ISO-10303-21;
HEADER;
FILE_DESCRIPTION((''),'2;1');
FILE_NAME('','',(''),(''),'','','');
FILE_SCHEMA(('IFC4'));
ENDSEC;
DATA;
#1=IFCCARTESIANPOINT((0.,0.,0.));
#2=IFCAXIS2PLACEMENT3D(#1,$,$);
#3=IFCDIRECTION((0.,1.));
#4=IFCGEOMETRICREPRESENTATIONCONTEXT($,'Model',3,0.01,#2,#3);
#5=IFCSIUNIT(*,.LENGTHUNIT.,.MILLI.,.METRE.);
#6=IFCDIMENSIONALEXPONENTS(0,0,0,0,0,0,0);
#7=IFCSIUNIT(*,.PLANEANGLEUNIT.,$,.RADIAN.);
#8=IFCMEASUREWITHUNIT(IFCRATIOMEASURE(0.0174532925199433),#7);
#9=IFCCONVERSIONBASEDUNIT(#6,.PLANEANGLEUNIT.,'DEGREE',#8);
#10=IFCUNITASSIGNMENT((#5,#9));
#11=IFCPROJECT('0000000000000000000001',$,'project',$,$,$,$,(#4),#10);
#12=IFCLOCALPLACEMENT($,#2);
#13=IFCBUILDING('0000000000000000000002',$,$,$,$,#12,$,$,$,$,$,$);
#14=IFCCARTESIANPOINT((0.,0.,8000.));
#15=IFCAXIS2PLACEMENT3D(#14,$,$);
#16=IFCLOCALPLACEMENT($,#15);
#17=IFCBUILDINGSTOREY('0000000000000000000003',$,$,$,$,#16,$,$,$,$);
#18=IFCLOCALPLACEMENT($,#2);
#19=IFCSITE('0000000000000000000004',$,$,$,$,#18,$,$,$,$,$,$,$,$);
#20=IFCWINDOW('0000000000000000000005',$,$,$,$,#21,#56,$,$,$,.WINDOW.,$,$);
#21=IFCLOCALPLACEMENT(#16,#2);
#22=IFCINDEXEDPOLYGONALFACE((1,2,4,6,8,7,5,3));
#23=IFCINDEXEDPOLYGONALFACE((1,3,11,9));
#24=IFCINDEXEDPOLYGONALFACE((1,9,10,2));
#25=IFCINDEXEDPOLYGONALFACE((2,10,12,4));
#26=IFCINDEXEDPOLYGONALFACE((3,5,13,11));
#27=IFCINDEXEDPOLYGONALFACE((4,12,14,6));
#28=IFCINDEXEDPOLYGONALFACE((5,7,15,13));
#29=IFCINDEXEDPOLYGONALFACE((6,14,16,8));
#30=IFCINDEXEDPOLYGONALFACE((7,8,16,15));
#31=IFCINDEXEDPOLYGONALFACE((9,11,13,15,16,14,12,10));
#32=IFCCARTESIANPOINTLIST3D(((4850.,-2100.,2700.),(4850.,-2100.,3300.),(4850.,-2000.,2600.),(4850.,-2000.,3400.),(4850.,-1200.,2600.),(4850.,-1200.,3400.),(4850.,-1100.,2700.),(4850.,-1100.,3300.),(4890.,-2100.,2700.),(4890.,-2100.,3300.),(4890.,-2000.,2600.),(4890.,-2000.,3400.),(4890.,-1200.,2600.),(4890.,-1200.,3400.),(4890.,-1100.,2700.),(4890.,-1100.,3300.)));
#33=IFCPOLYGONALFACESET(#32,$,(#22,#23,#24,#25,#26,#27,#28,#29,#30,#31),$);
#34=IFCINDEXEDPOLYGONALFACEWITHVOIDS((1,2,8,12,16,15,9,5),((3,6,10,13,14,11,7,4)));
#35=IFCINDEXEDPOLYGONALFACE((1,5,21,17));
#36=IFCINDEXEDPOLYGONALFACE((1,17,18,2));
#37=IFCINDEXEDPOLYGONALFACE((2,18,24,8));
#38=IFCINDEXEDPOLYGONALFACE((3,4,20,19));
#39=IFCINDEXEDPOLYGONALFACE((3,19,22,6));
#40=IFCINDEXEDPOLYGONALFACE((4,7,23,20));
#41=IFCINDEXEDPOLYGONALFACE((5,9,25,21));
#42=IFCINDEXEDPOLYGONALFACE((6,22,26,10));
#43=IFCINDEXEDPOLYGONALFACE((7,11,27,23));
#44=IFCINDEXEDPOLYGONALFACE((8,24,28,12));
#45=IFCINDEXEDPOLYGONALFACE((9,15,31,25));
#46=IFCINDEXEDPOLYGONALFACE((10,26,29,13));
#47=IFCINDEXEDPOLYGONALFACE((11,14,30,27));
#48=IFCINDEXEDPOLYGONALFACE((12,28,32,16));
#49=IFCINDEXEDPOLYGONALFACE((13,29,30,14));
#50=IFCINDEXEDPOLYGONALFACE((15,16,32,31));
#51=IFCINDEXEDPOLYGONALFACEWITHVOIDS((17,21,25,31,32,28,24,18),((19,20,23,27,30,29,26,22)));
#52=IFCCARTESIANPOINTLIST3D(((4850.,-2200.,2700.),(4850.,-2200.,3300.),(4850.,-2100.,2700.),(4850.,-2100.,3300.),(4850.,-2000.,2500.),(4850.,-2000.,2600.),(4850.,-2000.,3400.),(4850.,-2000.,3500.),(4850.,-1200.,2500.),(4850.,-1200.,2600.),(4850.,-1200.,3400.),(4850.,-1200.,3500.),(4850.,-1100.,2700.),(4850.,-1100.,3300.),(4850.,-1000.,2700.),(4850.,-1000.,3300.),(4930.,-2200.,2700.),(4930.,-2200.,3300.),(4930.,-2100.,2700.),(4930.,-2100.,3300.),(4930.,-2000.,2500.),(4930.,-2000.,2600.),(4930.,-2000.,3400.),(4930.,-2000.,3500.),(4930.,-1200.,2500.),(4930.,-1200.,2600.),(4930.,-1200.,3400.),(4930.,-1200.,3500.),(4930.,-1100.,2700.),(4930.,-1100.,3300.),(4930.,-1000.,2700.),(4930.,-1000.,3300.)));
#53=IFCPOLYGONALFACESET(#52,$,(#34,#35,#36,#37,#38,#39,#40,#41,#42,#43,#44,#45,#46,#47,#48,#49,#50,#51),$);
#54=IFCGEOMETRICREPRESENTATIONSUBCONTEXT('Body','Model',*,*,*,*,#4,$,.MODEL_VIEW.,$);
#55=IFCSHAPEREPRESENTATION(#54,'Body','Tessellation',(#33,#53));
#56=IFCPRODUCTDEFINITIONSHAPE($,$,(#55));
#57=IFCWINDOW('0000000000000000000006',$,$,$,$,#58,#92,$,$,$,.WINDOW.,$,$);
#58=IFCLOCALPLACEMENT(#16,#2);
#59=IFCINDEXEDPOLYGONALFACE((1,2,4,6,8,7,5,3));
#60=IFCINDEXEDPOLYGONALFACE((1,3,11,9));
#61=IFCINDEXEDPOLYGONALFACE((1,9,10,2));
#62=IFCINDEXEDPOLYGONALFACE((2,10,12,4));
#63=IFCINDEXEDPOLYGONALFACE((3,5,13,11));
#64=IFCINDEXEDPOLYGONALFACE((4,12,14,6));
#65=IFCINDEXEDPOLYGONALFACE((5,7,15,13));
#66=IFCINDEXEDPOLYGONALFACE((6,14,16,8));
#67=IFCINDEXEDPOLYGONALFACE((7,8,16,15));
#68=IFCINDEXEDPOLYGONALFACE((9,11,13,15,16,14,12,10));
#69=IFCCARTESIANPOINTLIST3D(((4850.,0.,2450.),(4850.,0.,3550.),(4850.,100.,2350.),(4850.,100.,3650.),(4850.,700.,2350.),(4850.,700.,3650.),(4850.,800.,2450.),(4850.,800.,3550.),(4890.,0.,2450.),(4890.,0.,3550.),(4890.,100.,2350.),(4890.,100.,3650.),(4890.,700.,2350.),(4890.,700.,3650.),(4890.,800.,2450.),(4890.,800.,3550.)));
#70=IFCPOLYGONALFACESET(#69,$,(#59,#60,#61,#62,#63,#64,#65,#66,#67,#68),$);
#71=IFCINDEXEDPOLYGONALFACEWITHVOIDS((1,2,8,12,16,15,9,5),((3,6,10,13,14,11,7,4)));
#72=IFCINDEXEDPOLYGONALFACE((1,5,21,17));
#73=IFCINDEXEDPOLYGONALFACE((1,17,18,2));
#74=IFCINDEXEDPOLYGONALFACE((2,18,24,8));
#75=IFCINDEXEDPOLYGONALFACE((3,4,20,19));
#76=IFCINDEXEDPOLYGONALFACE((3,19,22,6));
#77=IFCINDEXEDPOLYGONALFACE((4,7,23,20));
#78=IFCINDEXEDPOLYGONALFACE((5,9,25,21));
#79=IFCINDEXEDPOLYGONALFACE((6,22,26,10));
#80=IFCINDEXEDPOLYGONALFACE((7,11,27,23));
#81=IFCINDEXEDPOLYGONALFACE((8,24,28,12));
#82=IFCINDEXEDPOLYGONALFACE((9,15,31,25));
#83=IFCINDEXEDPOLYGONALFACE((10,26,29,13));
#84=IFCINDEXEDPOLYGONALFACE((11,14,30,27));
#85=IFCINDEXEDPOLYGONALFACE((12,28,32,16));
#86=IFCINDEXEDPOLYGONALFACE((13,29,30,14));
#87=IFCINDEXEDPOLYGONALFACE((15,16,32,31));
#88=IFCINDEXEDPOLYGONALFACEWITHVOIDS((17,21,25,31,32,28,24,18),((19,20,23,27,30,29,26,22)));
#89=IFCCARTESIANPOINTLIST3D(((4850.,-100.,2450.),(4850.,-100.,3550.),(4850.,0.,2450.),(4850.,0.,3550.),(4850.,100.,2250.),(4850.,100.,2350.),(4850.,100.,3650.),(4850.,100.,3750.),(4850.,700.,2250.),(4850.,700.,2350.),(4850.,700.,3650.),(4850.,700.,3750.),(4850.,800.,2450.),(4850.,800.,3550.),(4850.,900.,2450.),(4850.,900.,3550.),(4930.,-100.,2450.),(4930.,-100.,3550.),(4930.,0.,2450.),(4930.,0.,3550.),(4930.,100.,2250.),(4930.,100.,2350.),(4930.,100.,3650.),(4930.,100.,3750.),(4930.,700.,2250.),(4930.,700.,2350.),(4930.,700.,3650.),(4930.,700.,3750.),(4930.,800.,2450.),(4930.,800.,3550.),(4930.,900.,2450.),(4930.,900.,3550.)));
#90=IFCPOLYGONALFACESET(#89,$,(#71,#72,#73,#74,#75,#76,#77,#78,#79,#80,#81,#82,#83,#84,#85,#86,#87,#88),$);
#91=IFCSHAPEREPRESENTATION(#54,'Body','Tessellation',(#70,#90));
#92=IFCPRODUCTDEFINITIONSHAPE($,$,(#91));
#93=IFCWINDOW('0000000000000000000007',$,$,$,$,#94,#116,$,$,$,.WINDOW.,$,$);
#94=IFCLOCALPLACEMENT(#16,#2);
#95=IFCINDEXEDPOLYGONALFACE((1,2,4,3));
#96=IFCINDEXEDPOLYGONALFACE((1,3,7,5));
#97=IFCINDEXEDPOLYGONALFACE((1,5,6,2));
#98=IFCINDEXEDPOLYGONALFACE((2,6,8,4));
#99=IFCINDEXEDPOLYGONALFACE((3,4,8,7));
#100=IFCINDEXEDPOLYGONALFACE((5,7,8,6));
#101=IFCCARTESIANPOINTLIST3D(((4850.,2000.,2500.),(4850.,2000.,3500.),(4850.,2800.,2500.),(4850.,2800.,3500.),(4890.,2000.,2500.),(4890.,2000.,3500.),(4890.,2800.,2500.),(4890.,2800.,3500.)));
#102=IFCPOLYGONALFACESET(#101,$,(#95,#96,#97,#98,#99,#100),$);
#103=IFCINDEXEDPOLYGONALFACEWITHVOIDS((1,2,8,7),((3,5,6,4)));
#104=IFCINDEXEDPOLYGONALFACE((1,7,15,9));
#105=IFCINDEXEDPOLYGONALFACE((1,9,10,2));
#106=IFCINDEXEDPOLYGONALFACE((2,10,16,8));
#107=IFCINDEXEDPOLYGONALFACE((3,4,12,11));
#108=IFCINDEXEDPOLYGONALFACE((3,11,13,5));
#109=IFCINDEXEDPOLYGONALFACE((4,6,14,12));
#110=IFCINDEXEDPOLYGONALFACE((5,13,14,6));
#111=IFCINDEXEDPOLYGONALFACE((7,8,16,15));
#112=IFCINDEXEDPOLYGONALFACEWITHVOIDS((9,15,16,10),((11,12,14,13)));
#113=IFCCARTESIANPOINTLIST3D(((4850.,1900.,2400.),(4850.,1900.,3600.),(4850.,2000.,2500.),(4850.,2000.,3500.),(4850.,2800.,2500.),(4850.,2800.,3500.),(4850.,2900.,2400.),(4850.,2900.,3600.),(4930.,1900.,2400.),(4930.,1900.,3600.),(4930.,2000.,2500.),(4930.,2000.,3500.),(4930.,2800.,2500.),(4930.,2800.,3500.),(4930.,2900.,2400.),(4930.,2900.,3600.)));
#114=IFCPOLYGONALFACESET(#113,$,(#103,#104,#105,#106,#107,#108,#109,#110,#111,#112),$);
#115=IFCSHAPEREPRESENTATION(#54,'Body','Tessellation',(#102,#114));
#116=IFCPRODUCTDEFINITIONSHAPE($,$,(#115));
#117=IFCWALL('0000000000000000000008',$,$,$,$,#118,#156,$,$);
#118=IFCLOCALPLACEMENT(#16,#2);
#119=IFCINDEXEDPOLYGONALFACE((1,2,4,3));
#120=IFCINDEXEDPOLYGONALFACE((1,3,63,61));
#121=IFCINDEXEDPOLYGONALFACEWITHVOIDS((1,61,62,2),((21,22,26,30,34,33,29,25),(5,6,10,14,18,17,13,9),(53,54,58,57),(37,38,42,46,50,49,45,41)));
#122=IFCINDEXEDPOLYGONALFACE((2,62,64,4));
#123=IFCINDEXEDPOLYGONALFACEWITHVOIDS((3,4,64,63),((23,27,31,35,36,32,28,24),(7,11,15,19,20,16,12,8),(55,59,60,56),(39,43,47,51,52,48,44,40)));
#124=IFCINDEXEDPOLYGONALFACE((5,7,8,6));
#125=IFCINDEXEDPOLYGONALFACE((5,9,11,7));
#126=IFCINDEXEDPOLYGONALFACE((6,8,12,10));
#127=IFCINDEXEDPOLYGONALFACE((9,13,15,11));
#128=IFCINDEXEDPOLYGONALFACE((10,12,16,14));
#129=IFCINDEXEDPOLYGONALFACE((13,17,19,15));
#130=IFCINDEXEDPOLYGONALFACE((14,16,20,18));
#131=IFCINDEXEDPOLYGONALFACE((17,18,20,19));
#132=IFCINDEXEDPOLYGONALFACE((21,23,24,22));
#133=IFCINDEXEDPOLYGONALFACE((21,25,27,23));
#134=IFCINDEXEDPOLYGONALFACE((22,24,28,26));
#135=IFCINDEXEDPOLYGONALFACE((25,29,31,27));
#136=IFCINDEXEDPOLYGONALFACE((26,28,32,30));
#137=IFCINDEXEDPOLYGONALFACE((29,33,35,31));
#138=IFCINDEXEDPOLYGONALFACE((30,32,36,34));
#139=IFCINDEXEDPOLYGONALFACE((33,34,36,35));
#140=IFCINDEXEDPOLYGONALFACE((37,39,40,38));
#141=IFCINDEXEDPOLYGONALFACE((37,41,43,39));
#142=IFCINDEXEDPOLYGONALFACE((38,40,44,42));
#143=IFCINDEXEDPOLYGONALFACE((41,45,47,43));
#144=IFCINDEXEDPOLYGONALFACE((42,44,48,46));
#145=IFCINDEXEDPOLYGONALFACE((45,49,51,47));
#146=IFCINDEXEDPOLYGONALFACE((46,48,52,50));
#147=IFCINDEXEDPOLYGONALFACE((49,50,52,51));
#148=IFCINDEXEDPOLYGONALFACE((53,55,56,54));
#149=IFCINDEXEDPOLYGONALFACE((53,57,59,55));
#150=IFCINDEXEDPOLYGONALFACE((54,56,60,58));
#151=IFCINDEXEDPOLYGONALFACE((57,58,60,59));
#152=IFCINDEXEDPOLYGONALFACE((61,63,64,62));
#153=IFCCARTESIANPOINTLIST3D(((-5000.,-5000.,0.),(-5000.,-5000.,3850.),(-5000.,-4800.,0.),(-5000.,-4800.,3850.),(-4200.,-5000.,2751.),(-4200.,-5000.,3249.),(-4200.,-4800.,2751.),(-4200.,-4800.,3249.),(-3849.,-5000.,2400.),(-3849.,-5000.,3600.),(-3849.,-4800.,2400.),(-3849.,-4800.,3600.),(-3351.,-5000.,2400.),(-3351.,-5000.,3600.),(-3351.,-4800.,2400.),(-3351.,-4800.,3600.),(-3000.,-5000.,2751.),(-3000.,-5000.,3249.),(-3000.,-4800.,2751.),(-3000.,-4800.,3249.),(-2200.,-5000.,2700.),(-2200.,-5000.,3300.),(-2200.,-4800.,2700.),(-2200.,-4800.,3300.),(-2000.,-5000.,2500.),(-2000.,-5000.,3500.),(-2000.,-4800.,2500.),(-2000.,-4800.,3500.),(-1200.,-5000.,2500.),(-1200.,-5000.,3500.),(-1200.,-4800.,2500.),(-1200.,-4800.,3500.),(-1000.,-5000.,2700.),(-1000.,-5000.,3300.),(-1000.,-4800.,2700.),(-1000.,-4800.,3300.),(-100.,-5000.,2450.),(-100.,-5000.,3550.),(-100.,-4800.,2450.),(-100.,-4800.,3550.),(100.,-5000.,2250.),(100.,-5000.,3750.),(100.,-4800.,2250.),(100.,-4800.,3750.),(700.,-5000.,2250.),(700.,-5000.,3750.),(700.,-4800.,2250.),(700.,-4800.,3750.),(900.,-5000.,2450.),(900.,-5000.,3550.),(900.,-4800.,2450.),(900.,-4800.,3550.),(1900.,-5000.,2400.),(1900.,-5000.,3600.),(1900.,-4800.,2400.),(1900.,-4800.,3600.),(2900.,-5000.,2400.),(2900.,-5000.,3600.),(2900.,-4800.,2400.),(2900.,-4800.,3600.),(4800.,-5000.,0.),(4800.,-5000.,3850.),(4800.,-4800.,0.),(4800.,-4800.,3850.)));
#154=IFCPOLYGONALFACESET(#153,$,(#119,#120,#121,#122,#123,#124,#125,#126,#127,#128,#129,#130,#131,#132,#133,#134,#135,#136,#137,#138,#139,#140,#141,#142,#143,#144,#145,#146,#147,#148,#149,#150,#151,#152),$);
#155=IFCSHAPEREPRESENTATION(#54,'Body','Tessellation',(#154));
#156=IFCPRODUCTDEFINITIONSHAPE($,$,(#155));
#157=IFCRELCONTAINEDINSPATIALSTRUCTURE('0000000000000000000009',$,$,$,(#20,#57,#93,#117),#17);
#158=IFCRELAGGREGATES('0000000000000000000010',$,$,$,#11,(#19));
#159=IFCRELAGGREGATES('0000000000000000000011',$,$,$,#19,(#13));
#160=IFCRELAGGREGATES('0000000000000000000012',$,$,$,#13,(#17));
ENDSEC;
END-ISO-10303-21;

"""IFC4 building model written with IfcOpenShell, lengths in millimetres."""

from ifc_helpers import new_model, entity, si_unit, converted_unit, direction, frame, origin, origin_2d, place, context, subcontext, project, spatial, polyline, rectangle, outline, extrude, element, save


model = new_model("IFC4")

# Units and contexts
model_context = context("Model", 3, precision=0.01, world=origin(), true_north=direction((0.0, 1.0)))
body_context = subcontext(model_context, "Body", "Model", "MODEL_VIEW")
ifc_project = project(units=[si_unit("LENGTHUNIT", "METRE", prefix="MILLI"), converted_unit("PLANEANGLEUNIT", "DEGREE", entity("IfcRatioMeasure", 0.0174532925199433), si_unit("PLANEANGLEUNIT", "RADIAN"), dimensions=[0, 0, 0, 0, 0, 0, 0])], contexts=[model_context])

# Site, building, storey
site_placement = place(None, origin())
site = spatial("IfcSite", under=ifc_project, at=site_placement)
building_placement = place(None, origin())
building = spatial("IfcBuilding", under=site, at=building_placement)
storey_placement = place(None, frame((0.0, 0.0, 8000.0)))
storey = spatial("IfcBuildingStorey", under=building, at=storey_placement)

# Shared definitions
cartesian_point_1 = entity("IfcCartesianPoint", [-500.0, -300.0])
shared_polyline_1 = entity("IfcPolyline", [cartesian_point_1, entity("IfcCartesianPoint", [-500.0, 300.0]), entity("IfcCartesianPoint", [-400.0, 400.0]), entity("IfcCartesianPoint", [400.0, 400.0]), entity("IfcCartesianPoint", [500.0, 300.0]), entity("IfcCartesianPoint", [500.0, -300.0]), entity("IfcCartesianPoint", [400.0, -400.0]), entity("IfcCartesianPoint", [-400.0, -400.0]), cartesian_point_1])
cartesian_point_2 = entity("IfcCartesianPoint", [-400.0, -550.0])
shared_polyline_2 = entity("IfcPolyline", [cartesian_point_2, entity("IfcCartesianPoint", [-400.0, 550.0]), entity("IfcCartesianPoint", [-300.0, 650.0]), entity("IfcCartesianPoint", [300.0, 650.0]), entity("IfcCartesianPoint", [400.0, 550.0]), entity("IfcCartesianPoint", [400.0, -550.0]), entity("IfcCartesianPoint", [300.0, -650.0]), entity("IfcCartesianPoint", [-300.0, -650.0]), cartesian_point_2])
cartesian_point_3 = entity("IfcCartesianPoint", [-400.0, -500.0])
shared_polyline_3 = entity("IfcPolyline", [cartesian_point_3, entity("IfcCartesianPoint", [-400.0, 500.0]), entity("IfcCartesianPoint", [-400.0, 500.0]), entity("IfcCartesianPoint", [400.0, 500.0]), entity("IfcCartesianPoint", [400.0, 500.0]), entity("IfcCartesianPoint", [400.0, -500.0]), entity("IfcCartesianPoint", [400.0, -500.0]), entity("IfcCartesianPoint", [-400.0, -500.0]), cartesian_point_3])

# Shared definitions
wall_1_placement = place(storey_placement, frame((4900.0, -100.0, 0.0), z_axis=(0.0, 0.0, 1.0), x_axis=(0.0, 1.0, 0.0)))
window_1_placement = place(wall_1_placement, frame((-1500.0, 50.0, 3000.0)))
window_2_placement = place(wall_1_placement, frame((500.0, 50.0, 3000.0)))
window_3_placement = place(wall_1_placement, frame((2500.0, 50.0, 3000.0)))

# Windows
cartesian_point_4 = entity("IfcCartesianPoint", [-600.0, -300.0])
element("IfcWindow", 1, at=window_1_placement, inside=storey, PredefinedType="WINDOW", context=body_context, shape_type="SweptSolid", body=[
    entity("IfcExtrudedAreaSolid", entity("IfcArbitraryClosedProfileDef", "AREA", None, shared_polyline_1), entity("IfcAxis2Placement3D", entity("IfcCartesianPoint", [0.0, 0.0, 0.0]), entity("IfcDirection", [0.0, -1.0, 0.0]), entity("IfcDirection", [1.0, 0.0, 0.0])), entity("IfcDirection", [0.0, 0.0, 1.0]), 40.0),
    entity("IfcExtrudedAreaSolid", entity("IfcArbitraryProfileDefWithVoids", "AREA", None, entity("IfcPolyline", [cartesian_point_4, entity("IfcCartesianPoint", [-600.0, 300.0]), entity("IfcCartesianPoint", [-400.0, 500.0]), entity("IfcCartesianPoint", [400.0, 500.0]), entity("IfcCartesianPoint", [600.0, 300.0]), entity("IfcCartesianPoint", [600.0, -300.0]), entity("IfcCartesianPoint", [400.0, -500.0]), entity("IfcCartesianPoint", [-400.0, -500.0]), cartesian_point_4]), [shared_polyline_1]), entity("IfcAxis2Placement3D", entity("IfcCartesianPoint", [0.0, 0.0, 0.0]), entity("IfcDirection", [0.0, -1.0, 0.0]), entity("IfcDirection", [1.0, 0.0, 0.0])), entity("IfcDirection", [0.0, 0.0, 1.0]), 80.0),
])
cartesian_point_5 = entity("IfcCartesianPoint", [-500.0, -550.0])
element("IfcWindow", 2, at=window_2_placement, inside=storey, PredefinedType="WINDOW", context=body_context, shape_type="SweptSolid", body=[
    entity("IfcExtrudedAreaSolid", entity("IfcArbitraryClosedProfileDef", "AREA", None, shared_polyline_2), entity("IfcAxis2Placement3D", entity("IfcCartesianPoint", [0.0, 0.0, 0.0]), entity("IfcDirection", [0.0, -1.0, 0.0]), entity("IfcDirection", [1.0, 0.0, 0.0])), entity("IfcDirection", [0.0, 0.0, 1.0]), 40.0),
    entity("IfcExtrudedAreaSolid", entity("IfcArbitraryProfileDefWithVoids", "AREA", None, entity("IfcPolyline", [cartesian_point_5, entity("IfcCartesianPoint", [-500.0, 550.0]), entity("IfcCartesianPoint", [-300.0, 750.0]), entity("IfcCartesianPoint", [300.0, 750.0]), entity("IfcCartesianPoint", [500.0, 550.0]), entity("IfcCartesianPoint", [500.0, -550.0]), entity("IfcCartesianPoint", [300.0, -750.0]), entity("IfcCartesianPoint", [-300.0, -750.0]), cartesian_point_5]), [shared_polyline_2]), entity("IfcAxis2Placement3D", entity("IfcCartesianPoint", [0.0, 0.0, 0.0]), entity("IfcDirection", [0.0, -1.0, 0.0]), entity("IfcDirection", [1.0, 0.0, 0.0])), entity("IfcDirection", [0.0, 0.0, 1.0]), 80.0),
])
cartesian_point_6 = entity("IfcCartesianPoint", [-500.0, -600.0])
element("IfcWindow", 3, at=window_3_placement, inside=storey, PredefinedType="WINDOW", context=body_context, shape_type="SweptSolid", body=[
    entity("IfcExtrudedAreaSolid", entity("IfcArbitraryClosedProfileDef", "AREA", None, shared_polyline_3), entity("IfcAxis2Placement3D", entity("IfcCartesianPoint", [0.0, 0.0, 0.0]), entity("IfcDirection", [0.0, -1.0, 0.0]), entity("IfcDirection", [1.0, 0.0, 0.0])), entity("IfcDirection", [0.0, 0.0, 1.0]), 40.0),
    entity("IfcExtrudedAreaSolid", entity("IfcArbitraryProfileDefWithVoids", "AREA", None, entity("IfcPolyline", [cartesian_point_6, entity("IfcCartesianPoint", [-500.0, 600.0]), entity("IfcCartesianPoint", [-500.0, 600.0]), entity("IfcCartesianPoint", [500.0, 600.0]), entity("IfcCartesianPoint", [500.0, 600.0]), entity("IfcCartesianPoint", [500.0, -600.0]), entity("IfcCartesianPoint", [500.0, -600.0]), entity("IfcCartesianPoint", [-500.0, -600.0]), cartesian_point_6]), [shared_polyline_3]), entity("IfcAxis2Placement3D", entity("IfcCartesianPoint", [0.0, 0.0, 0.0]), entity("IfcDirection", [0.0, -1.0, 0.0]), entity("IfcDirection", [1.0, 0.0, 0.0])), entity("IfcDirection", [0.0, 0.0, 1.0]), 80.0),
])

# Wall, openings
wall_2_placement = place(storey_placement, frame((-100.0, -4900.0, 0.0), z_axis=(0.0, 0.0, 1.0), x_axis=(1.0, 0.0, 0.0)))
wall_2 = element("IfcWall", 4, at=wall_2_placement, inside=storey, context=body_context, shape_type="SweptSolid", body=[
    extrude(rectangle(XDim=9800.0, YDim=200.0, at=origin_2d()), origin(), (0.0, 0.0, 1.0), 3850.0),
])
window_4_placement = place(wall_2_placement, frame((-3500.0, 50.0, 3000.0)))
opening_1_placement = place(window_4_placement, frame((0.0, 50.0, 0.0)))
element("IfcOpeningElement", 5, at=opening_1_placement, cuts=wall_2, context=body_context, shape_type="SweptSolid", body=[
    extrude(outline(polyline([(-600.0, -249.0), (-600.0, 249.0), (-249.0, 600.0), (249.0, 600.0), (600.0, 249.0), (600.0, -249.0), (249.0, -600.0), (-249.0, -600.0), (-600.0, -249.0)])), frame((0.0, 0.0, 0.0), z_axis=(0.0, -1.0, 0.0), x_axis=(1.0, 0.0, 0.0)), (0.0, 0.0, 1.0), 200.0),
])
window_5_placement = place(wall_2_placement, frame((-1500.0, 50.0, 3000.0)))
opening_2_placement = place(window_5_placement, frame((0.0, 50.0, 0.0)))
element("IfcOpeningElement", 6, at=opening_2_placement, cuts=wall_2, context=body_context, shape_type="SweptSolid", body=[
    extrude(outline(polyline([(-600.0, -300.0), (-600.0, 300.0), (-400.0, 500.0), (400.0, 500.0), (600.0, 300.0), (600.0, -300.0), (400.0, -500.0), (-400.0, -500.0), (-600.0, -300.0)])), frame((0.0, 0.0, 0.0), z_axis=(0.0, -1.0, 0.0), x_axis=(1.0, 0.0, 0.0)), (0.0, 0.0, 1.0), 200.0),
])
window_6_placement = place(wall_2_placement, frame((500.0, 50.0, 3000.0)))
opening_3_placement = place(window_6_placement, frame((0.0, 50.0, 0.0)))
element("IfcOpeningElement", 7, at=opening_3_placement, cuts=wall_2, context=body_context, shape_type="SweptSolid", body=[
    extrude(outline(polyline([(-500.0, -550.0), (-500.0, 550.0), (-300.0, 750.0), (300.0, 750.0), (500.0, 550.0), (500.0, -550.0), (300.0, -750.0), (-300.0, -750.0), (-500.0, -550.0)])), frame((0.0, 0.0, 0.0), z_axis=(0.0, -1.0, 0.0), x_axis=(1.0, 0.0, 0.0)), (0.0, 0.0, 1.0), 200.0),
])
window_7_placement = place(wall_2_placement, frame((2500.0, 50.0, 3000.0)))
opening_4_placement = place(window_7_placement, frame((0.0, 50.0, 0.0)))
element("IfcOpeningElement", 8, at=opening_4_placement, cuts=wall_2, context=body_context, shape_type="SweptSolid", body=[
    extrude(outline(polyline([(-500.0, -600.0), (-500.0, 600.0), (-500.0, 600.0), (500.0, 600.0), (500.0, 600.0), (500.0, -600.0), (500.0, -600.0), (-500.0, -600.0), (-500.0, -600.0)])), frame((0.0, 0.0, 0.0), z_axis=(0.0, -1.0, 0.0), x_axis=(1.0, 0.0, 0.0)), (0.0, 0.0, 1.0), 200.0),
])

save(model, "model.ifc")
